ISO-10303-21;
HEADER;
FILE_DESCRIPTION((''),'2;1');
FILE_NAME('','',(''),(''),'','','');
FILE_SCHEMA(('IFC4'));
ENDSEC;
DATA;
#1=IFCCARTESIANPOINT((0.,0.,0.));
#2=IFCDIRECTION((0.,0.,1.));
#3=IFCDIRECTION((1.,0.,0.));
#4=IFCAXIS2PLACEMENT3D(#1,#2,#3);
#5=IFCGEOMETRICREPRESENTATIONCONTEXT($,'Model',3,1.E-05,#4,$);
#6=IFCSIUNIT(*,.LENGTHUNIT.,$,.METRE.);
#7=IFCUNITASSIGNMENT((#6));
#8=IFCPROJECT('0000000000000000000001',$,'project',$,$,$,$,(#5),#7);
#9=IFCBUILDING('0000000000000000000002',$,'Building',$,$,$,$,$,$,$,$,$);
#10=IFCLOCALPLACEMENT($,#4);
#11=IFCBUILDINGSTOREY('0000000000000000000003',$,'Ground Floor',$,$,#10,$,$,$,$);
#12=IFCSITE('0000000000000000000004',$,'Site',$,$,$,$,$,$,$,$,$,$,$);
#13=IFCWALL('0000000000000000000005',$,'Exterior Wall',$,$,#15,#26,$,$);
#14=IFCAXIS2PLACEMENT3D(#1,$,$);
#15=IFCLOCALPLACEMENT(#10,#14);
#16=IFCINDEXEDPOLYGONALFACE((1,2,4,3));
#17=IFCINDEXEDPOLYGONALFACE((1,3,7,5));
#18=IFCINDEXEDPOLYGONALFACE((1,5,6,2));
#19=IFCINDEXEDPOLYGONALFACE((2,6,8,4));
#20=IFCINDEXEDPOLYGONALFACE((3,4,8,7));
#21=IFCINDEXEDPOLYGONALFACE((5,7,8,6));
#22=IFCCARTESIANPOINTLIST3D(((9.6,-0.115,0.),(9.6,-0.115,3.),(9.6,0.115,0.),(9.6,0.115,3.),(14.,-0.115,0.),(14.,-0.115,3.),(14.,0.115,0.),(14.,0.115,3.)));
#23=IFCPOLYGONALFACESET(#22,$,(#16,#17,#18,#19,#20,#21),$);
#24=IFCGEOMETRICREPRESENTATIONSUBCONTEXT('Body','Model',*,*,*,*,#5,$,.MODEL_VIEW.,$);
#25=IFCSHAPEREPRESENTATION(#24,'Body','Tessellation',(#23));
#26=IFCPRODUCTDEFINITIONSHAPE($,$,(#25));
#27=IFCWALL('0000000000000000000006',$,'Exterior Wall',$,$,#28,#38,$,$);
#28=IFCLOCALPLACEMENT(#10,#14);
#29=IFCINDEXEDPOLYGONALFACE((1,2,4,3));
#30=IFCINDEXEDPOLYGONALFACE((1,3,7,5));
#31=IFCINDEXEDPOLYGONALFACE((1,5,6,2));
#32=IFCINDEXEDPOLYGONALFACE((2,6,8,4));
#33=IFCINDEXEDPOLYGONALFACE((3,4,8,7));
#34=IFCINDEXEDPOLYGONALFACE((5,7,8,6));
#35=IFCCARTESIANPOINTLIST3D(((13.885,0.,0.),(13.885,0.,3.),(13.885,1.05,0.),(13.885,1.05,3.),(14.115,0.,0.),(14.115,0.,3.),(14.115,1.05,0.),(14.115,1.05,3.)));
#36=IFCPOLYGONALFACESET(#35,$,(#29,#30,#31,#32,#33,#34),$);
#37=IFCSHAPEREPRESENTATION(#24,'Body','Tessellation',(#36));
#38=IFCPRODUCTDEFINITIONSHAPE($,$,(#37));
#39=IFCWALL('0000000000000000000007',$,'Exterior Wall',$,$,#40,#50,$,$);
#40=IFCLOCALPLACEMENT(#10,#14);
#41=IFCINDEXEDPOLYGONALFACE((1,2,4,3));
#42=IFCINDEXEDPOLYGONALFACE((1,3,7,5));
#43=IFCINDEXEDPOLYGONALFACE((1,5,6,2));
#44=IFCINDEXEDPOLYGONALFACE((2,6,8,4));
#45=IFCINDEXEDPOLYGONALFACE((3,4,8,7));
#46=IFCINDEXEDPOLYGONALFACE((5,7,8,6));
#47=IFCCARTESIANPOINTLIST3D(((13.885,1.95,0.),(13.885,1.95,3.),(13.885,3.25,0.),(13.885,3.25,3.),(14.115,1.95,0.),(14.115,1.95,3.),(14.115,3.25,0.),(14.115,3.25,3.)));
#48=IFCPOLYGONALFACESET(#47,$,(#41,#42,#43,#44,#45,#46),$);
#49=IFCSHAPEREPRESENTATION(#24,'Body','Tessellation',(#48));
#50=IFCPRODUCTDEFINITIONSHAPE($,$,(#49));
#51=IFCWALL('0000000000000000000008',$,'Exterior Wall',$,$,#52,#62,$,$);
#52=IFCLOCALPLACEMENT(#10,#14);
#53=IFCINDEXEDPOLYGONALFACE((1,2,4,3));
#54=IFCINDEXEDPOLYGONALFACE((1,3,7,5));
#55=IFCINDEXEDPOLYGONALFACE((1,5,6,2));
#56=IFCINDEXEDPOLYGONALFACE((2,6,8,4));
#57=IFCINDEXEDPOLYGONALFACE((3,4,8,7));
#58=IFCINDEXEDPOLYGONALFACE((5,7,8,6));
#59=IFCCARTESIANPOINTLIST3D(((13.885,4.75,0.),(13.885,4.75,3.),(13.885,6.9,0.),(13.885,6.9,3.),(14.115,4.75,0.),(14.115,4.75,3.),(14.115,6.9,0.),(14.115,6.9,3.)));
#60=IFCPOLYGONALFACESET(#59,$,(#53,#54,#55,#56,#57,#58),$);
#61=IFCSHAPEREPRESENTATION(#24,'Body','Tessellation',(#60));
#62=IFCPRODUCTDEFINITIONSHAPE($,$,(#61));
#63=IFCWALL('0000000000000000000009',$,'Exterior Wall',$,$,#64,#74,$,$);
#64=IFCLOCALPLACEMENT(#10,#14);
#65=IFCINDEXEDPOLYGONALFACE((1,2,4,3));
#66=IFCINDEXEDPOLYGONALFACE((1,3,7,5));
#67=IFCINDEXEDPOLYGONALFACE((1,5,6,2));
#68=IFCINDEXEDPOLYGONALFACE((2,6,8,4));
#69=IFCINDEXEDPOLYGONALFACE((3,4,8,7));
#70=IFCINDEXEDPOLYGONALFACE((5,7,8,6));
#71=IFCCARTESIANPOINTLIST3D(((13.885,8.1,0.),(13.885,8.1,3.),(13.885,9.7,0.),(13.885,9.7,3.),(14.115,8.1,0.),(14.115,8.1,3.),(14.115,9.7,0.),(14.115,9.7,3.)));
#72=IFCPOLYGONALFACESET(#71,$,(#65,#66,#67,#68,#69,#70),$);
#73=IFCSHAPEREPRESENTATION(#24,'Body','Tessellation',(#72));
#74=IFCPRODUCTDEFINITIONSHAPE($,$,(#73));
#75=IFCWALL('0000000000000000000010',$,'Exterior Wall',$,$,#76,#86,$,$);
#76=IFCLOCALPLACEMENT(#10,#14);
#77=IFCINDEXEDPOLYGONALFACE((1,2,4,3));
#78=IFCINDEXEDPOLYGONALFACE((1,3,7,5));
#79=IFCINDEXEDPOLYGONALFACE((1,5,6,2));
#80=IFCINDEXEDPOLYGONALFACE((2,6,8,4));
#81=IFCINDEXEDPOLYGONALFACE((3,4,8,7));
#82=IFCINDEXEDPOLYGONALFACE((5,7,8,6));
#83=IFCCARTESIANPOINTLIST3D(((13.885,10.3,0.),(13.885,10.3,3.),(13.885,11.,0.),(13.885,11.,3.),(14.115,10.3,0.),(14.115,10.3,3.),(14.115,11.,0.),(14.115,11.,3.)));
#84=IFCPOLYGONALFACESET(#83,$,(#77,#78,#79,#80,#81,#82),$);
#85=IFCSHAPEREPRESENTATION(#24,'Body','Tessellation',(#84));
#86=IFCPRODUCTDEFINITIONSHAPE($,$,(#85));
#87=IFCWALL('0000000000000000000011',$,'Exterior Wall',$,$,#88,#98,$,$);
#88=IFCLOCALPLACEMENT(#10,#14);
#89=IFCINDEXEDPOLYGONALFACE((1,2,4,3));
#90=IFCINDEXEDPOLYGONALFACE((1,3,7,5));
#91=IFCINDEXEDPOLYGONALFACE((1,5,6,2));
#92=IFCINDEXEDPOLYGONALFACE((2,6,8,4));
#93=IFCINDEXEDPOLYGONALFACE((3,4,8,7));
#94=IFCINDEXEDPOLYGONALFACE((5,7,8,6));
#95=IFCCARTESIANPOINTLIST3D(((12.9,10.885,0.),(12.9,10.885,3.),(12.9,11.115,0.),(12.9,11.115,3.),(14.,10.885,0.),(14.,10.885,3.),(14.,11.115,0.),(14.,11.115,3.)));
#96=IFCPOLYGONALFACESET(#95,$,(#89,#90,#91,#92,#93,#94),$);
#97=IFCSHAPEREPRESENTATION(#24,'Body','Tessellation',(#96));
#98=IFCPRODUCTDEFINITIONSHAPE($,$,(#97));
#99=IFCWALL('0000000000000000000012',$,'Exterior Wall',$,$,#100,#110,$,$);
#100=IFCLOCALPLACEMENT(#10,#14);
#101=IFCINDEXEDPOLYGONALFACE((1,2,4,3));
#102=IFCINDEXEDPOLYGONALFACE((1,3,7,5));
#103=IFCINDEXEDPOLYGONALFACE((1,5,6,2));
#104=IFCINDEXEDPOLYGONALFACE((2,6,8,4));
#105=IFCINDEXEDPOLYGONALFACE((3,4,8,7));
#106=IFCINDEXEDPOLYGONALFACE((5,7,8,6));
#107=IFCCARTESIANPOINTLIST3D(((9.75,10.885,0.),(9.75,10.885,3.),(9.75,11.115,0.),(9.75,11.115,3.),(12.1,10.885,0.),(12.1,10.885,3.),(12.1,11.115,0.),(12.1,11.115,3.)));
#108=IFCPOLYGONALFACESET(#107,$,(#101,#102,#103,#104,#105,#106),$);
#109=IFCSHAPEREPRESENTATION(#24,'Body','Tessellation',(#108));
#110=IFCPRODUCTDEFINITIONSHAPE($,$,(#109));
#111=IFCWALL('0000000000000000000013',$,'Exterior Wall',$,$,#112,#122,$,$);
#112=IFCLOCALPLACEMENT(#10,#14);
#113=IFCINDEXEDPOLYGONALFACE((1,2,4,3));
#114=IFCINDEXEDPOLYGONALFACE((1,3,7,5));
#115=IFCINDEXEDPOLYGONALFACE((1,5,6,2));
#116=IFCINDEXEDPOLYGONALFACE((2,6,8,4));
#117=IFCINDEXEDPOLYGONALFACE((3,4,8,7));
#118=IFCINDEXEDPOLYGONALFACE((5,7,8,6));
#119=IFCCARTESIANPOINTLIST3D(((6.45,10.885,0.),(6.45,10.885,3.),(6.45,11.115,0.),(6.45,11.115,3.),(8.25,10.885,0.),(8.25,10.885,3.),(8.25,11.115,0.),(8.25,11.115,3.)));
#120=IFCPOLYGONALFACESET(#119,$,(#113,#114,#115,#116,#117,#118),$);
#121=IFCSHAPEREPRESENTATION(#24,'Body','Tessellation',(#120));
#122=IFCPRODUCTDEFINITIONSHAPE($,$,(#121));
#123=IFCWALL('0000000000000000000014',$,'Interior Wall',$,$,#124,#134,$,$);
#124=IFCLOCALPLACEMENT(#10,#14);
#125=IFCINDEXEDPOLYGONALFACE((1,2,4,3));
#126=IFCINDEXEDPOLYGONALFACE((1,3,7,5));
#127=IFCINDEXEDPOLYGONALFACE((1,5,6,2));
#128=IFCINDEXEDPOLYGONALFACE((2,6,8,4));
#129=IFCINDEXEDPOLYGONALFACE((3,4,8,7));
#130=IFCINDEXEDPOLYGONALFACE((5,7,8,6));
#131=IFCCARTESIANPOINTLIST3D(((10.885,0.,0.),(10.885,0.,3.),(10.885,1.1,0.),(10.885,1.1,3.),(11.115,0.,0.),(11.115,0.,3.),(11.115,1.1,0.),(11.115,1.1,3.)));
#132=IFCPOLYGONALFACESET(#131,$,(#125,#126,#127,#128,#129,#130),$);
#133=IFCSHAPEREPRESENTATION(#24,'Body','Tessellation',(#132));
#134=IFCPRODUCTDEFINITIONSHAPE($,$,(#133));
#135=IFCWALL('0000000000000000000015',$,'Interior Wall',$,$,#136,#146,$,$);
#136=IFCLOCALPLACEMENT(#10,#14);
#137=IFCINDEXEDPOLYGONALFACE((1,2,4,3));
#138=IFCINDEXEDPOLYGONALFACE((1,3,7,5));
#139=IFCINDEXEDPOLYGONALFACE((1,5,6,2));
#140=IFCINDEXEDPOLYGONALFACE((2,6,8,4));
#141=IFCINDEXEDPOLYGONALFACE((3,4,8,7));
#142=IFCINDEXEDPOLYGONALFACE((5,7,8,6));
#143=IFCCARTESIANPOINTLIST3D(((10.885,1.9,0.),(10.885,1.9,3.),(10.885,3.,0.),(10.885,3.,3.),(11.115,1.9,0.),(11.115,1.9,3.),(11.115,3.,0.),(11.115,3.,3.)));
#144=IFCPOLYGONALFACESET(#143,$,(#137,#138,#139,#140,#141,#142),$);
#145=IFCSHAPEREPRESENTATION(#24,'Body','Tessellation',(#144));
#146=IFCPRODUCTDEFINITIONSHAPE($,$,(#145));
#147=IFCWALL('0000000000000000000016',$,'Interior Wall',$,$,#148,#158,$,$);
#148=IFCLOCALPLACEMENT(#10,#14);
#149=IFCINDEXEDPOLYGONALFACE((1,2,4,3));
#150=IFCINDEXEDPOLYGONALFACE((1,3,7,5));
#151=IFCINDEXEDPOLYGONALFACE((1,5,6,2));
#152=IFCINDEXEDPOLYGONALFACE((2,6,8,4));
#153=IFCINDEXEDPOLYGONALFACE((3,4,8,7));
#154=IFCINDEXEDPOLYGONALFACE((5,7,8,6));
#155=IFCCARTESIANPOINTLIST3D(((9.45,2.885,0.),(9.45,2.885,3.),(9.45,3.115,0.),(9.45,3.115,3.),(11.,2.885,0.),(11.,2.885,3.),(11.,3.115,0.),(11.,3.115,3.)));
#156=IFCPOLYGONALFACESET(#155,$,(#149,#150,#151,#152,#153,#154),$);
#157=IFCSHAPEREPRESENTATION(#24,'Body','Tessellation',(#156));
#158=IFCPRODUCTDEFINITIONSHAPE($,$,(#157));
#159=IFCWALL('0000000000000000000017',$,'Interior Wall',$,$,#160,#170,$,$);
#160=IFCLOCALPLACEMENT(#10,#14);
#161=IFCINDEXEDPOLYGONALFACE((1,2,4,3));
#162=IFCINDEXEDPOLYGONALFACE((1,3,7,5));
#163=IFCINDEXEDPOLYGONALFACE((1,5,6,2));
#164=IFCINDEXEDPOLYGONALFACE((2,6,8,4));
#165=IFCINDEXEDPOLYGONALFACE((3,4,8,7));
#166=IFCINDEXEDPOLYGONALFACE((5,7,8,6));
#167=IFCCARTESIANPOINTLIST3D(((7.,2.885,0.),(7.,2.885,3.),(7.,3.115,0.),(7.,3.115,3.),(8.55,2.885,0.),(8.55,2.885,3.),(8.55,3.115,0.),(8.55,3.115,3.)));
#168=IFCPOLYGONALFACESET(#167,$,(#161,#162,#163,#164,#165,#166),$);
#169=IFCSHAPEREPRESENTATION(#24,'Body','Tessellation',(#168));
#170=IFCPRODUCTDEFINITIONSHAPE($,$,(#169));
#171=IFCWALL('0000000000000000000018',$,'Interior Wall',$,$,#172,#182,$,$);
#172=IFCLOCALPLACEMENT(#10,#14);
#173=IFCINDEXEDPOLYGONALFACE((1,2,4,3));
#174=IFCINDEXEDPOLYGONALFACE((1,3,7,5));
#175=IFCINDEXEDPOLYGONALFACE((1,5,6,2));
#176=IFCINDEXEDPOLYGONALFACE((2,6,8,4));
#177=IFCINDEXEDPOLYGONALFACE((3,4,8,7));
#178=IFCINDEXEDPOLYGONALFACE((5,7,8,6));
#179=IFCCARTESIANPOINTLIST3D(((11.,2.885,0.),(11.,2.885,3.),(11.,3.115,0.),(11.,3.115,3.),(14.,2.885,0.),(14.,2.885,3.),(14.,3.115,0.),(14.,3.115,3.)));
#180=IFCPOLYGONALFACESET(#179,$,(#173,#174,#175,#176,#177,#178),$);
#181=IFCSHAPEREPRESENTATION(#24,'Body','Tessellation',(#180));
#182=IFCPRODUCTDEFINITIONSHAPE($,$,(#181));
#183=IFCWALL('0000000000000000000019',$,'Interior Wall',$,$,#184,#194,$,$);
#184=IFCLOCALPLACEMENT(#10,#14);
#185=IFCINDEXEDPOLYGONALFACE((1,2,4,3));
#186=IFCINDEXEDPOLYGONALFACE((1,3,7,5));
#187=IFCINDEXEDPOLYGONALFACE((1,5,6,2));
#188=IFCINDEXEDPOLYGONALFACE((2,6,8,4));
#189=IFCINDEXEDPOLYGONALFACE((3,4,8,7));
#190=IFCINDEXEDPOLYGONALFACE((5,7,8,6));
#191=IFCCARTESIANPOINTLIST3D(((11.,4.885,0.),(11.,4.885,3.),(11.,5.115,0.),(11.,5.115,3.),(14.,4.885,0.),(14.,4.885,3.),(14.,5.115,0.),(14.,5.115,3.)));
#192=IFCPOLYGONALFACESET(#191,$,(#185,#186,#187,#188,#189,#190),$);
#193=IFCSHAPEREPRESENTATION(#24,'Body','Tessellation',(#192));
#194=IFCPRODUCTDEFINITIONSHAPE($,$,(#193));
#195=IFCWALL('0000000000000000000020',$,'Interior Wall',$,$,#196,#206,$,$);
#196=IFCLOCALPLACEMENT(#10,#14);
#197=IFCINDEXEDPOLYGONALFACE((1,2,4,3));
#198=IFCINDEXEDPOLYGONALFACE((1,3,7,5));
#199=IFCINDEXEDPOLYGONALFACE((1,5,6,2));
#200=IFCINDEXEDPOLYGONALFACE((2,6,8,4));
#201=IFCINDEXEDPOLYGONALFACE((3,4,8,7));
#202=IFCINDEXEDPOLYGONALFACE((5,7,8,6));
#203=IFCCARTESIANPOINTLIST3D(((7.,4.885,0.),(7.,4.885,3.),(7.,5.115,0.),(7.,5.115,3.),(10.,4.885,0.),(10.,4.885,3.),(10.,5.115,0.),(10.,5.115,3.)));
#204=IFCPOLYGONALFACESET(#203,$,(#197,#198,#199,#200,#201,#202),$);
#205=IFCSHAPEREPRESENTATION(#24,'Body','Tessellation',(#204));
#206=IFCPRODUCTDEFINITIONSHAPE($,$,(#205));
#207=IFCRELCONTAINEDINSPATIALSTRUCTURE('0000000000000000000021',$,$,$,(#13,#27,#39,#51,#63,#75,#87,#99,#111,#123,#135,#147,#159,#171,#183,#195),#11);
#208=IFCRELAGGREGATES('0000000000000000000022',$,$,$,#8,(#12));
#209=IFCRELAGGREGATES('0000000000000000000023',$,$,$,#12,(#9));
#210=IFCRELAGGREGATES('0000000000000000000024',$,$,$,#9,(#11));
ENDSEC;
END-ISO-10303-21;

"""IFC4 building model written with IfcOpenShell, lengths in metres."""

from ifc_helpers import new_model, si_unit, frame, origin_with_axes, place, context, subcontext, project, spatial, indexed_curve, outline, extrude, element, save


model = new_model("IFC4")

# Units and contexts
model_context = context("Model", 3, precision=1e-05, world=origin_with_axes())
body_context = subcontext(model_context, "Body", "Model", "MODEL_VIEW")
ifc_project = project(units=[si_unit("LENGTHUNIT", "METRE")], contexts=[model_context])

# Site, building, storey
site = spatial("IfcSite", under=ifc_project, Name="Site")
building = spatial("IfcBuilding", under=site, Name="Building")
storey_placement = place(None, origin_with_axes())
storey = spatial("IfcBuildingStorey", under=building, at=storey_placement, Name="Ground Floor")

# Walls
wall_1_placement = place(storey_placement, frame((9.6, 0.0, 0.0), z_axis=(0.0, 0.0, 1.0), x_axis=(1.0, 0.0, 0.0)))
element("IfcWall", 1, at=wall_1_placement, inside=storey, Name="Exterior Wall", context=body_context, shape_type="SweptSolid", body=[
    extrude(outline(indexed_curve([(0.0, 0.0), (0.0, 0.23), (4.4, 0.23), (4.4, 0.0), (0.0, 0.0)], self_intersect=False)), frame((0.0, -0.115, 0.0), z_axis=(0.0, 0.0, 1.0), x_axis=(1.0, 0.0, 0.0)), (0.0, 0.0, 1.0), 3.0),
])
wall_2_placement = place(storey_placement, frame((14.0, 0.0, 0.0), z_axis=(0.0, 0.0, 1.0), x_axis=(0.0, 1.0, 0.0)))
element("IfcWall", 2, at=wall_2_placement, inside=storey, Name="Exterior Wall", context=body_context, shape_type="SweptSolid", body=[
    extrude(outline(indexed_curve([(0.0, 0.0), (0.0, 0.23), (1.05, 0.23), (1.05, 0.0), (0.0, 0.0)], self_intersect=False)), frame((0.0, -0.115, 0.0), z_axis=(0.0, 0.0, 1.0), x_axis=(1.0, 0.0, 0.0)), (0.0, 0.0, 1.0), 3.0),
])
wall_3_placement = place(storey_placement, frame((14.0, 1.95, 0.0), z_axis=(0.0, 0.0, 1.0), x_axis=(0.0, 1.0, 0.0)))
element("IfcWall", 3, at=wall_3_placement, inside=storey, Name="Exterior Wall", context=body_context, shape_type="SweptSolid", body=[
    extrude(outline(indexed_curve([(0.0, 0.0), (0.0, 0.23), (1.3, 0.23), (1.3, 0.0), (0.0, 0.0)], self_intersect=False)), frame((0.0, -0.115, 0.0), z_axis=(0.0, 0.0, 1.0), x_axis=(1.0, 0.0, 0.0)), (0.0, 0.0, 1.0), 3.0),
])
wall_4_placement = place(storey_placement, frame((14.0, 4.75, 0.0), z_axis=(0.0, 0.0, 1.0), x_axis=(0.0, 1.0, 0.0)))
element("IfcWall", 4, at=wall_4_placement, inside=storey, Name="Exterior Wall", context=body_context, shape_type="SweptSolid", body=[
    extrude(outline(indexed_curve([(0.0, 0.0), (0.0, 0.23), (2.15, 0.23), (2.15, 0.0), (0.0, 0.0)], self_intersect=False)), frame((0.0, -0.115, 0.0), z_axis=(0.0, 0.0, 1.0), x_axis=(1.0, 0.0, 0.0)), (0.0, 0.0, 1.0), 3.0),
])
wall_5_placement = place(storey_placement, frame((14.0, 8.1, 0.0), z_axis=(0.0, 0.0, 1.0), x_axis=(0.0, 1.0, 0.0)))
element("IfcWall", 5, at=wall_5_placement, inside=storey, Name="Exterior Wall", context=body_context, shape_type="SweptSolid", body=[
    extrude(outline(indexed_curve([(0.0, 0.0), (0.0, 0.23), (1.6, 0.23), (1.6, 0.0), (0.0, 0.0)], self_intersect=False)), frame((0.0, -0.115, 0.0), z_axis=(0.0, 0.0, 1.0), x_axis=(1.0, 0.0, 0.0)), (0.0, 0.0, 1.0), 3.0),
])
wall_6_placement = place(storey_placement, frame((14.0, 10.3, 0.0), z_axis=(0.0, 0.0, 1.0), x_axis=(0.0, 1.0, 0.0)))
element("IfcWall", 6, at=wall_6_placement, inside=storey, Name="Exterior Wall", context=body_context, shape_type="SweptSolid", body=[
    extrude(outline(indexed_curve([(0.0, 0.0), (0.0, 0.23), (0.7, 0.23), (0.7, 0.0), (0.0, 0.0)], self_intersect=False)), frame((0.0, -0.115, 0.0), z_axis=(0.0, 0.0, 1.0), x_axis=(1.0, 0.0, 0.0)), (0.0, 0.0, 1.0), 3.0),
])
wall_7_placement = place(storey_placement, frame((14.0, 11.0, 0.0), z_axis=(0.0, 0.0, 1.0), x_axis=(-1.0, 0.0, 0.0)))
element("IfcWall", 7, at=wall_7_placement, inside=storey, Name="Exterior Wall", context=body_context, shape_type="SweptSolid", body=[
    extrude(outline(indexed_curve([(0.0, 0.0), (0.0, 0.23), (1.1, 0.23), (1.1, 0.0), (0.0, 0.0)], self_intersect=False)), frame((0.0, -0.115, 0.0), z_axis=(0.0, 0.0, 1.0), x_axis=(1.0, 0.0, 0.0)), (0.0, 0.0, 1.0), 3.0),
])
wall_8_placement = place(storey_placement, frame((12.1, 11.0, 0.0), z_axis=(0.0, 0.0, 1.0), x_axis=(-1.0, 0.0, 0.0)))
element("IfcWall", 8, at=wall_8_placement, inside=storey, Name="Exterior Wall", context=body_context, shape_type="SweptSolid", body=[
    extrude(outline(indexed_curve([(0.0, 0.0), (0.0, 0.23), (2.35, 0.23), (2.35, 0.0), (0.0, 0.0)], self_intersect=False)), frame((0.0, -0.115, 0.0), z_axis=(0.0, 0.0, 1.0), x_axis=(1.0, 0.0, 0.0)), (0.0, 0.0, 1.0), 3.0),
])
wall_9_placement = place(storey_placement, frame((8.25, 11.0, 0.0), z_axis=(0.0, 0.0, 1.0), x_axis=(-1.0, 0.0, 0.0)))
element("IfcWall", 9, at=wall_9_placement, inside=storey, Name="Exterior Wall", context=body_context, shape_type="SweptSolid", body=[
    extrude(outline(indexed_curve([(0.0, 0.0), (0.0, 0.23), (1.8, 0.23), (1.8, 0.0), (0.0, 0.0)], self_intersect=False)), frame((0.0, -0.115, 0.0), z_axis=(0.0, 0.0, 1.0), x_axis=(1.0, 0.0, 0.0)), (0.0, 0.0, 1.0), 3.0),
])
for number, where, z_axis, x_axis, name in (
    (10, (11.0, 0.0, 0.0), (0.0, 0.0, 1.0), (0.0, 1.0, 0.0), "Interior Wall"),
    (11, (11.0, 1.9, 0.0), (0.0, 0.0, 1.0), (0.0, 1.0, 0.0), "Interior Wall"),
):
    element("IfcWall", number, at=place(storey_placement, frame(where, z_axis=z_axis, x_axis=x_axis)), inside=storey, Name=name, context=body_context, shape_type="SweptSolid", body=[
        extrude(outline(indexed_curve([(0.0, 0.0), (0.0, 0.23), (1.1, 0.23), (1.1, 0.0), (0.0, 0.0)], self_intersect=False)), frame((0.0, -0.115, 0.0), z_axis=(0.0, 0.0, 1.0), x_axis=(1.0, 0.0, 0.0)), (0.0, 0.0, 1.0), 3.0),
    ])
for number, where, z_axis, x_axis, name in (
    (12, (11.0, 3.0, 0.0), (0.0, 0.0, 1.0), (-1.0, 0.0, 0.0), "Interior Wall"),
    (13, (8.55, 3.0, 0.0), (0.0, 0.0, 1.0), (-1.0, 0.0, 0.0), "Interior Wall"),
):
    element("IfcWall", number, at=place(storey_placement, frame(where, z_axis=z_axis, x_axis=x_axis)), inside=storey, Name=name, context=body_context, shape_type="SweptSolid", body=[
        extrude(outline(indexed_curve([(0.0, 0.0), (0.0, 0.23), (1.55, 0.23), (1.55, 0.0), (0.0, 0.0)], self_intersect=False)), frame((0.0, -0.115, 0.0), z_axis=(0.0, 0.0, 1.0), x_axis=(1.0, 0.0, 0.0)), (0.0, 0.0, 1.0), 3.0),
    ])
for number, where, z_axis, x_axis, name in (
    (14, (14.0, 3.0, 0.0), (0.0, 0.0, 1.0), (-1.0, 0.0, 0.0), "Interior Wall"),
    (15, (14.0, 5.0, 0.0), (0.0, 0.0, 1.0), (-1.0, 0.0, 0.0), "Interior Wall"),
    (16, (10.0, 5.0, 0.0), (0.0, 0.0, 1.0), (-1.0, 0.0, 0.0), "Interior Wall"),
):
    element("IfcWall", number, at=place(storey_placement, frame(where, z_axis=z_axis, x_axis=x_axis)), inside=storey, Name=name, context=body_context, shape_type="SweptSolid", body=[
        extrude(outline(indexed_curve([(0.0, 0.0), (0.0, 0.23), (3.0, 0.23), (3.0, 0.0), (0.0, 0.0)], self_intersect=False)), frame((0.0, -0.115, 0.0), z_axis=(0.0, 0.0, 1.0), x_axis=(1.0, 0.0, 0.0)), (0.0, 0.0, 1.0), 3.0),
    ])

save(model, "model.ifc")
